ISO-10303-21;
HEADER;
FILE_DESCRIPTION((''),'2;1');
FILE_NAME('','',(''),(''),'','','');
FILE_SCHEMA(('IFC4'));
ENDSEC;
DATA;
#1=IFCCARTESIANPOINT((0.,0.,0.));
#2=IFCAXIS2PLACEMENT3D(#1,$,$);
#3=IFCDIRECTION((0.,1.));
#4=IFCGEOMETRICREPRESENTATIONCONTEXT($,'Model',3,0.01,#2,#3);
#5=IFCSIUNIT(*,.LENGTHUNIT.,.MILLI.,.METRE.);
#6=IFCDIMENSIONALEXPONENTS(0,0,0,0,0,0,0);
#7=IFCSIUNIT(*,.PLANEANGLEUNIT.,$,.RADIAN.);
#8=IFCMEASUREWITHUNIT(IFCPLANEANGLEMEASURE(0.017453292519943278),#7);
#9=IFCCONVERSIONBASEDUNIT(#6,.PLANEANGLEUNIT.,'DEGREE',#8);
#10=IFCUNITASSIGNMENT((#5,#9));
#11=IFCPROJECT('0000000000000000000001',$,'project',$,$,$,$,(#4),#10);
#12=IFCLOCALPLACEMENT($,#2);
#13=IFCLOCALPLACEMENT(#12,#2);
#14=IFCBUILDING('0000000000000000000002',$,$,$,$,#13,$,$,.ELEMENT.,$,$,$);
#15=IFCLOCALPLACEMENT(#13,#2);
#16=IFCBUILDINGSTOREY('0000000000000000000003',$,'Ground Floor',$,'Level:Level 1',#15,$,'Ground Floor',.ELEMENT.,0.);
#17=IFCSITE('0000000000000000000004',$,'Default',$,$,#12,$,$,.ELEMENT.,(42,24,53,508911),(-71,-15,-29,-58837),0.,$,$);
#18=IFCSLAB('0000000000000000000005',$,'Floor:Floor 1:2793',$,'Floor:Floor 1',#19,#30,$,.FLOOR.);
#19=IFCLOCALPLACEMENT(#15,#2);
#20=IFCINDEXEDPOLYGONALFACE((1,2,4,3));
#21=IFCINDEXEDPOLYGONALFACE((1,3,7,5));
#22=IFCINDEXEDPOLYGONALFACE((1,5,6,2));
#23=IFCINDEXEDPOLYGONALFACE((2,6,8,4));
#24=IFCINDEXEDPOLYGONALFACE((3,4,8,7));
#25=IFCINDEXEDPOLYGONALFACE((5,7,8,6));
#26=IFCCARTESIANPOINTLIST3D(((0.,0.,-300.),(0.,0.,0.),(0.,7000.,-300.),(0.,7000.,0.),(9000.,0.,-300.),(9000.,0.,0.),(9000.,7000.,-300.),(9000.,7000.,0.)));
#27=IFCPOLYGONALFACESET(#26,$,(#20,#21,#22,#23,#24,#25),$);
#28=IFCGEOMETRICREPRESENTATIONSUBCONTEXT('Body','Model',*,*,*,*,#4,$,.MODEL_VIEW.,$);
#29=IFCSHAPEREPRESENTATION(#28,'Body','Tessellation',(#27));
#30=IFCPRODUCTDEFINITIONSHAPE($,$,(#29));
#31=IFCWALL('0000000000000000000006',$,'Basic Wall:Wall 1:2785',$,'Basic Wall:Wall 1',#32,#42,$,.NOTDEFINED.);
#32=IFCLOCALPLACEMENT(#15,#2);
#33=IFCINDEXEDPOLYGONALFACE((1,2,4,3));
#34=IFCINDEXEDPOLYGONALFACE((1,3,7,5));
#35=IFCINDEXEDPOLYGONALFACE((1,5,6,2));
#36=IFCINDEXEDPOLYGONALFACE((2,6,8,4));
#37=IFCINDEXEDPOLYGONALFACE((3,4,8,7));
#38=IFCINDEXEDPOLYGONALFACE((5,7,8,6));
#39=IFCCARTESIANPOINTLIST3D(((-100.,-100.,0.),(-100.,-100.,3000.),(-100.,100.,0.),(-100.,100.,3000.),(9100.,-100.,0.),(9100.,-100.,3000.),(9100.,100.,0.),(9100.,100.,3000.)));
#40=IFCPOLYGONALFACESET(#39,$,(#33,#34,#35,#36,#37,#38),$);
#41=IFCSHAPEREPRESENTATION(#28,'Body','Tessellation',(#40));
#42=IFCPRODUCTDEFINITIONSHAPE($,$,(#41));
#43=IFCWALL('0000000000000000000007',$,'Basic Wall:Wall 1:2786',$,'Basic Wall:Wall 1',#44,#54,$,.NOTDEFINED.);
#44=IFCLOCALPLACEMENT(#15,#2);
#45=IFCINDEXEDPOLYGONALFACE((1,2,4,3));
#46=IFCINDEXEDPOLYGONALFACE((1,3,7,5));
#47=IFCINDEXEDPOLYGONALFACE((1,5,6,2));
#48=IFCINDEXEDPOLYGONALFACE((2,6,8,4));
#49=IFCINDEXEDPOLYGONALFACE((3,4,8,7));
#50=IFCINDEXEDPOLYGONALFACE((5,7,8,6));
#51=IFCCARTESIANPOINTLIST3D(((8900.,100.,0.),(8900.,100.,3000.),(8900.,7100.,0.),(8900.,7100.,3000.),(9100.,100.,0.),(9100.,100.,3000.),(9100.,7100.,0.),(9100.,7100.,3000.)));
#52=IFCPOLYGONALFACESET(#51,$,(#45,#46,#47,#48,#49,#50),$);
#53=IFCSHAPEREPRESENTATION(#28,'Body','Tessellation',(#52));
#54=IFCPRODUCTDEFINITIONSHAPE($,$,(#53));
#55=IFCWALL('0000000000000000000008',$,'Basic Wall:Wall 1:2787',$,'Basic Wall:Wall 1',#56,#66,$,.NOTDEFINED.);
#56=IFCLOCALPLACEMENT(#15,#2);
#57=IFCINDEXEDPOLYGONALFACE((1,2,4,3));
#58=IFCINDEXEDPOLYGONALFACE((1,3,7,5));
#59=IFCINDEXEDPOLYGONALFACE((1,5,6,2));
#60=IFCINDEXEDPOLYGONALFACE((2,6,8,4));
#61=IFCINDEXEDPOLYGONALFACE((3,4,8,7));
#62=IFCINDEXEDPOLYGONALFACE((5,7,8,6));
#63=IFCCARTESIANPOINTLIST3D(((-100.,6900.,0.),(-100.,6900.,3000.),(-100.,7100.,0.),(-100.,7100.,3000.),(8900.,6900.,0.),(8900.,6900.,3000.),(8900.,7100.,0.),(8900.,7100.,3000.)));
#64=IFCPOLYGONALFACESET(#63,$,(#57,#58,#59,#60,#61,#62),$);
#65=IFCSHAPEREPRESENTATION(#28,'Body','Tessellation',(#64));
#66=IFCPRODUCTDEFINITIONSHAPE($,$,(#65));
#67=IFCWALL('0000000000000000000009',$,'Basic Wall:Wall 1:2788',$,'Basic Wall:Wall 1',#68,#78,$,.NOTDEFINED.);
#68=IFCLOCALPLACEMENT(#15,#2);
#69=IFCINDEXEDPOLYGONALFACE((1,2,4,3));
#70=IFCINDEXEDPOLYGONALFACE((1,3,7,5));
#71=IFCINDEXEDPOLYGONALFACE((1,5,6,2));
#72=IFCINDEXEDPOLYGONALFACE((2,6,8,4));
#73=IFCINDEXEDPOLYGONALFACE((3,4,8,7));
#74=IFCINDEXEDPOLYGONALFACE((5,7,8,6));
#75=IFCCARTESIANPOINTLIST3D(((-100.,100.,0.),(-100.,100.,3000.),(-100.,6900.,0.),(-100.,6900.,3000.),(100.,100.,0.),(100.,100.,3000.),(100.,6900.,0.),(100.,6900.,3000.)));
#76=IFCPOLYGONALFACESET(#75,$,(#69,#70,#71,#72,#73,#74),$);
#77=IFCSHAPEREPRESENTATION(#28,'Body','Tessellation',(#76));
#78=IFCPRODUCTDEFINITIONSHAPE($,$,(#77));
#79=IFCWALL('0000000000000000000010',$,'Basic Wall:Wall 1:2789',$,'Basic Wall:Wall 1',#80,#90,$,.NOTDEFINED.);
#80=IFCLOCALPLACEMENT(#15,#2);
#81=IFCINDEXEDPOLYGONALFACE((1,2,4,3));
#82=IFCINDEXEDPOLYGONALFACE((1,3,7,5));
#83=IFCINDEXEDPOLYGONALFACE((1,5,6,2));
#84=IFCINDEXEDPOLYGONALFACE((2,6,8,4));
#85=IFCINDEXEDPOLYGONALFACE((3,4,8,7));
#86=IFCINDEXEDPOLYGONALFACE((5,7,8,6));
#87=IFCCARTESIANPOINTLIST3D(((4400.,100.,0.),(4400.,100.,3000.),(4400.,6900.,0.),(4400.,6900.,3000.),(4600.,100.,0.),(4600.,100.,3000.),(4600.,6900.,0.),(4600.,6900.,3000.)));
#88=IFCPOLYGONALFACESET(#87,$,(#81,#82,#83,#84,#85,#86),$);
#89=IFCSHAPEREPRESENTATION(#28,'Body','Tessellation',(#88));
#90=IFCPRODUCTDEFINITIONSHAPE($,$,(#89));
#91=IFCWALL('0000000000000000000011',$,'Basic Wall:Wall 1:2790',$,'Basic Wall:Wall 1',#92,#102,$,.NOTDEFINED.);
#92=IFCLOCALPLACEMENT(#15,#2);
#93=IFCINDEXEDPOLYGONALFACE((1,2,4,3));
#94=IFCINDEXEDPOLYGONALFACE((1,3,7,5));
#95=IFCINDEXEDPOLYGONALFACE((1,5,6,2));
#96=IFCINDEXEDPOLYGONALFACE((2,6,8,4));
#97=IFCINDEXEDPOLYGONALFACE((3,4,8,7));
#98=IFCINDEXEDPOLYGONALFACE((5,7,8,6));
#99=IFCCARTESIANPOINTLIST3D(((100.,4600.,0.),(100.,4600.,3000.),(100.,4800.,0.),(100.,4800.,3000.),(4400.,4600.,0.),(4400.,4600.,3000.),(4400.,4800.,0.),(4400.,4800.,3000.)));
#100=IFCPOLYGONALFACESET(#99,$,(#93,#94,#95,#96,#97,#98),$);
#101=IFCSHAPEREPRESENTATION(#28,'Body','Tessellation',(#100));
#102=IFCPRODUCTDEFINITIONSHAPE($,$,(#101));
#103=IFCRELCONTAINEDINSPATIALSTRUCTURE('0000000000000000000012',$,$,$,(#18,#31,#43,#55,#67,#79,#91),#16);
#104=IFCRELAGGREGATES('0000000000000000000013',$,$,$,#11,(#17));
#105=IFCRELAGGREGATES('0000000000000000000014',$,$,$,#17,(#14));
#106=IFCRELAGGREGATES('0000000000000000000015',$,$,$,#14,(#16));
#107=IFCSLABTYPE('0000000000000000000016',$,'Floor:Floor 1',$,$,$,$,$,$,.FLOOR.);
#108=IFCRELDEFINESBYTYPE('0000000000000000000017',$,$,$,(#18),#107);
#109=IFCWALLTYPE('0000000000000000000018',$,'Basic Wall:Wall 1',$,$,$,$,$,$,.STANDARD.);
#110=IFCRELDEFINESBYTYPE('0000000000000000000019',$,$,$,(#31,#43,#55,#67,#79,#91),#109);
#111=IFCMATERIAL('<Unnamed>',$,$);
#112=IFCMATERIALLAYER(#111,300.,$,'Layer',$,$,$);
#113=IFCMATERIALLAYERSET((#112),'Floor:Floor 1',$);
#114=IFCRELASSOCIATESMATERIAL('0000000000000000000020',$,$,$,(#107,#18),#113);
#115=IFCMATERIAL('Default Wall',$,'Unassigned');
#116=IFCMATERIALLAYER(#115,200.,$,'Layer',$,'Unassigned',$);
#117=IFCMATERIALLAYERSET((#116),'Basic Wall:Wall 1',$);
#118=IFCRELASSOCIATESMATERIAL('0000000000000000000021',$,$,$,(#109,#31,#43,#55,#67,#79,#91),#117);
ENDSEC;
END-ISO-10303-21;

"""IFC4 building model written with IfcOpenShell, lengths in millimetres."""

from ifc_helpers import new_model, entity, si_unit, converted_unit, direction, frame, frame_2d, origin, origin_2d_with_axis, place, context, subcontext, project, spatial, rectangle, extrude, material, layer, layer_set, layer_usage, type_object, element, save


model = new_model("IFC4")

# Units and contexts
model_context = context("Model", 3, precision=0.01, world=origin(), true_north=direction((0.0, 1.0)))
body_context = subcontext(model_context, "Body", "Model", "MODEL_VIEW")
ifc_project = project(units=[si_unit("LENGTHUNIT", "METRE", prefix="MILLI"), converted_unit("PLANEANGLEUNIT", "DEGREE", entity("IfcPlaneAngleMeasure", 0.017453292519943278), si_unit("PLANEANGLEUNIT", "RADIAN"), dimensions=[0, 0, 0, 0, 0, 0, 0])], contexts=[model_context])

# Site, building, storey
site_placement = place(None, origin())
site = spatial("IfcSite", under=ifc_project, at=site_placement, Name="Default", CompositionType="ELEMENT", RefLatitude=(42, 24, 53, 508911), RefLongitude=(-71, -15, -29, -58837), RefElevation=0.0)
building_placement = place(site_placement, origin())
building = spatial("IfcBuilding", under=site, at=building_placement, CompositionType="ELEMENT")
storey_placement = place(building_placement, origin())
storey = spatial("IfcBuildingStorey", under=building, at=storey_placement, Name="Ground Floor", ObjectType="Level:Level 1", LongName="Ground Floor", CompositionType="ELEMENT", Elevation=0.0)

# Slab
ifc_material_1 = material(Name="<Unnamed>")
ifc_layer_1 = layer(ifc_material_1, 300.0, Name="Layer")
ifc_layer_set_1 = layer_set([ifc_layer_1], Name="Floor:Floor 1")
ifc_layer_usage_1 = layer_usage(ifc_layer_set_1, "AXIS3", "POSITIVE", 0.0)
slab_type = type_object("IfcSlabType", Name="Floor:Floor 1", PredefinedType="FLOOR", material=ifc_layer_set_1)
slab_placement = place(storey_placement, origin())
element("IfcSlab", 1, at=slab_placement, inside=storey, type_object=slab_type, material=ifc_layer_usage_1, Name="Floor:Floor 1:2793", ObjectType="Floor:Floor 1", PredefinedType="FLOOR", context=body_context, shape_type="SweptSolid", body=[
    extrude(rectangle(XDim=7000.0, YDim=9000.0, at=origin_2d_with_axis()), frame((4500.0, 3500.0, 0.0), z_axis=(0.0, 0.0, -1.0), x_axis=(0.0, 1.0, 0.0)), (0.0, 0.0, 1.0), 300.0),
])

# Walls
ifc_material_2 = material(Name="Default Wall", Category="Unassigned")
ifc_layer_2 = layer(ifc_material_2, 200.0, Name="Layer", Category="Unassigned")
ifc_layer_set_2 = layer_set([ifc_layer_2], Name="Basic Wall:Wall 1")
ifc_layer_usage_2 = layer_usage(ifc_layer_set_2, "AXIS2", "NEGATIVE", 100.0)
wall_type = type_object("IfcWallType", Name="Basic Wall:Wall 1", PredefinedType="STANDARD", material=ifc_layer_set_2)
wall_1_placement = place(storey_placement, frame((-100.0, 0.0, 0.0)))
element("IfcWall", 2, at=wall_1_placement, inside=storey, type_object=wall_type, material=ifc_layer_usage_2, Name="Basic Wall:Wall 1:2785", ObjectType="Basic Wall:Wall 1", PredefinedType="NOTDEFINED", context=body_context, shape_type="SweptSolid", body=[
    extrude(rectangle(XDim=9200.0, YDim=200.0, at=frame_2d((4600.0, 0.0), x_axis=(-1.0, 0.0))), origin(), (0.0, 0.0, 1.0), 3000.0),
])
ifc_layer_usage_3 = layer_usage(ifc_layer_set_2, "AXIS2", "NEGATIVE", 100.0)
wall_2_placement = place(storey_placement, frame((9000.0, 100.0, 0.0), z_axis=(0.0, 0.0, 1.0), x_axis=(0.0, 1.0, 0.0)))
element("IfcWall", 3, at=wall_2_placement, inside=storey, type_object=wall_type, material=ifc_layer_usage_3, Name="Basic Wall:Wall 1:2786", ObjectType="Basic Wall:Wall 1", PredefinedType="NOTDEFINED", context=body_context, shape_type="SweptSolid", body=[
    extrude(rectangle(XDim=7000.0, YDim=200.0, at=frame_2d((3500.0, 0.0), x_axis=(-1.0, 0.0))), origin(), (0.0, 0.0, 1.0), 3000.0),
])
ifc_layer_usage_4 = layer_usage(ifc_layer_set_2, "AXIS2", "NEGATIVE", 100.0)
wall_3_placement = place(storey_placement, frame((8900.0, 7000.0, 0.0), z_axis=(0.0, 0.0, 1.0), x_axis=(-1.0, 0.0, 0.0)))
element("IfcWall", 4, at=wall_3_placement, inside=storey, type_object=wall_type, material=ifc_layer_usage_4, Name="Basic Wall:Wall 1:2787", ObjectType="Basic Wall:Wall 1", PredefinedType="NOTDEFINED", context=body_context, shape_type="SweptSolid", body=[
    extrude(rectangle(XDim=9000.0, YDim=200.0, at=frame_2d((4500.0, 0.0), x_axis=(-1.0, 0.0))), origin(), (0.0, 0.0, 1.0), 3000.0),
])
ifc_layer_usage_5 = layer_usage(ifc_layer_set_2, "AXIS2", "NEGATIVE", 100.0)
wall_4_placement = place(storey_placement, frame((0.0, 6900.0, 0.0), z_axis=(0.0, 0.0, 1.0), x_axis=(0.0, -1.0, 0.0)))
element("IfcWall", 5, at=wall_4_placement, inside=storey, type_object=wall_type, material=ifc_layer_usage_5, Name="Basic Wall:Wall 1:2788", ObjectType="Basic Wall:Wall 1", PredefinedType="NOTDEFINED", context=body_context, shape_type="SweptSolid", body=[
    extrude(rectangle(XDim=6800.0, YDim=200.0, at=frame_2d((3400.0, 0.0), x_axis=(-1.0, 0.0))), origin(), (0.0, 0.0, 1.0), 3000.0),
])
ifc_layer_usage_6 = layer_usage(ifc_layer_set_2, "AXIS2", "NEGATIVE", 100.0)
wall_5_placement = place(storey_placement, frame((4500.0, 100.0, 0.0), z_axis=(0.0, 0.0, 1.0), x_axis=(0.0, 1.0, 0.0)))
element("IfcWall", 6, at=wall_5_placement, inside=storey, type_object=wall_type, material=ifc_layer_usage_6, Name="Basic Wall:Wall 1:2789", ObjectType="Basic Wall:Wall 1", PredefinedType="NOTDEFINED", context=body_context, shape_type="SweptSolid", body=[
    extrude(rectangle(XDim=6800.0, YDim=200.0, at=frame_2d((3400.0, 0.0), x_axis=(-1.0, 0.0))), origin(), (0.0, 0.0, 1.0), 3000.0),
])
ifc_layer_usage_7 = layer_usage(ifc_layer_set_2, "AXIS2", "NEGATIVE", 100.0)
wall_6_placement = place(storey_placement, frame((100.0, 4700.0, 0.0)))
element("IfcWall", 7, at=wall_6_placement, inside=storey, type_object=wall_type, material=ifc_layer_usage_7, Name="Basic Wall:Wall 1:2790", ObjectType="Basic Wall:Wall 1", PredefinedType="NOTDEFINED", context=body_context, shape_type="SweptSolid", body=[
    extrude(rectangle(XDim=4300.0, YDim=200.0, at=frame_2d((2150.0, 0.0), x_axis=(-1.0, 0.0))), origin(), (0.0, 0.0, 1.0), 3000.0),
])

save(model, "model.ifc")
